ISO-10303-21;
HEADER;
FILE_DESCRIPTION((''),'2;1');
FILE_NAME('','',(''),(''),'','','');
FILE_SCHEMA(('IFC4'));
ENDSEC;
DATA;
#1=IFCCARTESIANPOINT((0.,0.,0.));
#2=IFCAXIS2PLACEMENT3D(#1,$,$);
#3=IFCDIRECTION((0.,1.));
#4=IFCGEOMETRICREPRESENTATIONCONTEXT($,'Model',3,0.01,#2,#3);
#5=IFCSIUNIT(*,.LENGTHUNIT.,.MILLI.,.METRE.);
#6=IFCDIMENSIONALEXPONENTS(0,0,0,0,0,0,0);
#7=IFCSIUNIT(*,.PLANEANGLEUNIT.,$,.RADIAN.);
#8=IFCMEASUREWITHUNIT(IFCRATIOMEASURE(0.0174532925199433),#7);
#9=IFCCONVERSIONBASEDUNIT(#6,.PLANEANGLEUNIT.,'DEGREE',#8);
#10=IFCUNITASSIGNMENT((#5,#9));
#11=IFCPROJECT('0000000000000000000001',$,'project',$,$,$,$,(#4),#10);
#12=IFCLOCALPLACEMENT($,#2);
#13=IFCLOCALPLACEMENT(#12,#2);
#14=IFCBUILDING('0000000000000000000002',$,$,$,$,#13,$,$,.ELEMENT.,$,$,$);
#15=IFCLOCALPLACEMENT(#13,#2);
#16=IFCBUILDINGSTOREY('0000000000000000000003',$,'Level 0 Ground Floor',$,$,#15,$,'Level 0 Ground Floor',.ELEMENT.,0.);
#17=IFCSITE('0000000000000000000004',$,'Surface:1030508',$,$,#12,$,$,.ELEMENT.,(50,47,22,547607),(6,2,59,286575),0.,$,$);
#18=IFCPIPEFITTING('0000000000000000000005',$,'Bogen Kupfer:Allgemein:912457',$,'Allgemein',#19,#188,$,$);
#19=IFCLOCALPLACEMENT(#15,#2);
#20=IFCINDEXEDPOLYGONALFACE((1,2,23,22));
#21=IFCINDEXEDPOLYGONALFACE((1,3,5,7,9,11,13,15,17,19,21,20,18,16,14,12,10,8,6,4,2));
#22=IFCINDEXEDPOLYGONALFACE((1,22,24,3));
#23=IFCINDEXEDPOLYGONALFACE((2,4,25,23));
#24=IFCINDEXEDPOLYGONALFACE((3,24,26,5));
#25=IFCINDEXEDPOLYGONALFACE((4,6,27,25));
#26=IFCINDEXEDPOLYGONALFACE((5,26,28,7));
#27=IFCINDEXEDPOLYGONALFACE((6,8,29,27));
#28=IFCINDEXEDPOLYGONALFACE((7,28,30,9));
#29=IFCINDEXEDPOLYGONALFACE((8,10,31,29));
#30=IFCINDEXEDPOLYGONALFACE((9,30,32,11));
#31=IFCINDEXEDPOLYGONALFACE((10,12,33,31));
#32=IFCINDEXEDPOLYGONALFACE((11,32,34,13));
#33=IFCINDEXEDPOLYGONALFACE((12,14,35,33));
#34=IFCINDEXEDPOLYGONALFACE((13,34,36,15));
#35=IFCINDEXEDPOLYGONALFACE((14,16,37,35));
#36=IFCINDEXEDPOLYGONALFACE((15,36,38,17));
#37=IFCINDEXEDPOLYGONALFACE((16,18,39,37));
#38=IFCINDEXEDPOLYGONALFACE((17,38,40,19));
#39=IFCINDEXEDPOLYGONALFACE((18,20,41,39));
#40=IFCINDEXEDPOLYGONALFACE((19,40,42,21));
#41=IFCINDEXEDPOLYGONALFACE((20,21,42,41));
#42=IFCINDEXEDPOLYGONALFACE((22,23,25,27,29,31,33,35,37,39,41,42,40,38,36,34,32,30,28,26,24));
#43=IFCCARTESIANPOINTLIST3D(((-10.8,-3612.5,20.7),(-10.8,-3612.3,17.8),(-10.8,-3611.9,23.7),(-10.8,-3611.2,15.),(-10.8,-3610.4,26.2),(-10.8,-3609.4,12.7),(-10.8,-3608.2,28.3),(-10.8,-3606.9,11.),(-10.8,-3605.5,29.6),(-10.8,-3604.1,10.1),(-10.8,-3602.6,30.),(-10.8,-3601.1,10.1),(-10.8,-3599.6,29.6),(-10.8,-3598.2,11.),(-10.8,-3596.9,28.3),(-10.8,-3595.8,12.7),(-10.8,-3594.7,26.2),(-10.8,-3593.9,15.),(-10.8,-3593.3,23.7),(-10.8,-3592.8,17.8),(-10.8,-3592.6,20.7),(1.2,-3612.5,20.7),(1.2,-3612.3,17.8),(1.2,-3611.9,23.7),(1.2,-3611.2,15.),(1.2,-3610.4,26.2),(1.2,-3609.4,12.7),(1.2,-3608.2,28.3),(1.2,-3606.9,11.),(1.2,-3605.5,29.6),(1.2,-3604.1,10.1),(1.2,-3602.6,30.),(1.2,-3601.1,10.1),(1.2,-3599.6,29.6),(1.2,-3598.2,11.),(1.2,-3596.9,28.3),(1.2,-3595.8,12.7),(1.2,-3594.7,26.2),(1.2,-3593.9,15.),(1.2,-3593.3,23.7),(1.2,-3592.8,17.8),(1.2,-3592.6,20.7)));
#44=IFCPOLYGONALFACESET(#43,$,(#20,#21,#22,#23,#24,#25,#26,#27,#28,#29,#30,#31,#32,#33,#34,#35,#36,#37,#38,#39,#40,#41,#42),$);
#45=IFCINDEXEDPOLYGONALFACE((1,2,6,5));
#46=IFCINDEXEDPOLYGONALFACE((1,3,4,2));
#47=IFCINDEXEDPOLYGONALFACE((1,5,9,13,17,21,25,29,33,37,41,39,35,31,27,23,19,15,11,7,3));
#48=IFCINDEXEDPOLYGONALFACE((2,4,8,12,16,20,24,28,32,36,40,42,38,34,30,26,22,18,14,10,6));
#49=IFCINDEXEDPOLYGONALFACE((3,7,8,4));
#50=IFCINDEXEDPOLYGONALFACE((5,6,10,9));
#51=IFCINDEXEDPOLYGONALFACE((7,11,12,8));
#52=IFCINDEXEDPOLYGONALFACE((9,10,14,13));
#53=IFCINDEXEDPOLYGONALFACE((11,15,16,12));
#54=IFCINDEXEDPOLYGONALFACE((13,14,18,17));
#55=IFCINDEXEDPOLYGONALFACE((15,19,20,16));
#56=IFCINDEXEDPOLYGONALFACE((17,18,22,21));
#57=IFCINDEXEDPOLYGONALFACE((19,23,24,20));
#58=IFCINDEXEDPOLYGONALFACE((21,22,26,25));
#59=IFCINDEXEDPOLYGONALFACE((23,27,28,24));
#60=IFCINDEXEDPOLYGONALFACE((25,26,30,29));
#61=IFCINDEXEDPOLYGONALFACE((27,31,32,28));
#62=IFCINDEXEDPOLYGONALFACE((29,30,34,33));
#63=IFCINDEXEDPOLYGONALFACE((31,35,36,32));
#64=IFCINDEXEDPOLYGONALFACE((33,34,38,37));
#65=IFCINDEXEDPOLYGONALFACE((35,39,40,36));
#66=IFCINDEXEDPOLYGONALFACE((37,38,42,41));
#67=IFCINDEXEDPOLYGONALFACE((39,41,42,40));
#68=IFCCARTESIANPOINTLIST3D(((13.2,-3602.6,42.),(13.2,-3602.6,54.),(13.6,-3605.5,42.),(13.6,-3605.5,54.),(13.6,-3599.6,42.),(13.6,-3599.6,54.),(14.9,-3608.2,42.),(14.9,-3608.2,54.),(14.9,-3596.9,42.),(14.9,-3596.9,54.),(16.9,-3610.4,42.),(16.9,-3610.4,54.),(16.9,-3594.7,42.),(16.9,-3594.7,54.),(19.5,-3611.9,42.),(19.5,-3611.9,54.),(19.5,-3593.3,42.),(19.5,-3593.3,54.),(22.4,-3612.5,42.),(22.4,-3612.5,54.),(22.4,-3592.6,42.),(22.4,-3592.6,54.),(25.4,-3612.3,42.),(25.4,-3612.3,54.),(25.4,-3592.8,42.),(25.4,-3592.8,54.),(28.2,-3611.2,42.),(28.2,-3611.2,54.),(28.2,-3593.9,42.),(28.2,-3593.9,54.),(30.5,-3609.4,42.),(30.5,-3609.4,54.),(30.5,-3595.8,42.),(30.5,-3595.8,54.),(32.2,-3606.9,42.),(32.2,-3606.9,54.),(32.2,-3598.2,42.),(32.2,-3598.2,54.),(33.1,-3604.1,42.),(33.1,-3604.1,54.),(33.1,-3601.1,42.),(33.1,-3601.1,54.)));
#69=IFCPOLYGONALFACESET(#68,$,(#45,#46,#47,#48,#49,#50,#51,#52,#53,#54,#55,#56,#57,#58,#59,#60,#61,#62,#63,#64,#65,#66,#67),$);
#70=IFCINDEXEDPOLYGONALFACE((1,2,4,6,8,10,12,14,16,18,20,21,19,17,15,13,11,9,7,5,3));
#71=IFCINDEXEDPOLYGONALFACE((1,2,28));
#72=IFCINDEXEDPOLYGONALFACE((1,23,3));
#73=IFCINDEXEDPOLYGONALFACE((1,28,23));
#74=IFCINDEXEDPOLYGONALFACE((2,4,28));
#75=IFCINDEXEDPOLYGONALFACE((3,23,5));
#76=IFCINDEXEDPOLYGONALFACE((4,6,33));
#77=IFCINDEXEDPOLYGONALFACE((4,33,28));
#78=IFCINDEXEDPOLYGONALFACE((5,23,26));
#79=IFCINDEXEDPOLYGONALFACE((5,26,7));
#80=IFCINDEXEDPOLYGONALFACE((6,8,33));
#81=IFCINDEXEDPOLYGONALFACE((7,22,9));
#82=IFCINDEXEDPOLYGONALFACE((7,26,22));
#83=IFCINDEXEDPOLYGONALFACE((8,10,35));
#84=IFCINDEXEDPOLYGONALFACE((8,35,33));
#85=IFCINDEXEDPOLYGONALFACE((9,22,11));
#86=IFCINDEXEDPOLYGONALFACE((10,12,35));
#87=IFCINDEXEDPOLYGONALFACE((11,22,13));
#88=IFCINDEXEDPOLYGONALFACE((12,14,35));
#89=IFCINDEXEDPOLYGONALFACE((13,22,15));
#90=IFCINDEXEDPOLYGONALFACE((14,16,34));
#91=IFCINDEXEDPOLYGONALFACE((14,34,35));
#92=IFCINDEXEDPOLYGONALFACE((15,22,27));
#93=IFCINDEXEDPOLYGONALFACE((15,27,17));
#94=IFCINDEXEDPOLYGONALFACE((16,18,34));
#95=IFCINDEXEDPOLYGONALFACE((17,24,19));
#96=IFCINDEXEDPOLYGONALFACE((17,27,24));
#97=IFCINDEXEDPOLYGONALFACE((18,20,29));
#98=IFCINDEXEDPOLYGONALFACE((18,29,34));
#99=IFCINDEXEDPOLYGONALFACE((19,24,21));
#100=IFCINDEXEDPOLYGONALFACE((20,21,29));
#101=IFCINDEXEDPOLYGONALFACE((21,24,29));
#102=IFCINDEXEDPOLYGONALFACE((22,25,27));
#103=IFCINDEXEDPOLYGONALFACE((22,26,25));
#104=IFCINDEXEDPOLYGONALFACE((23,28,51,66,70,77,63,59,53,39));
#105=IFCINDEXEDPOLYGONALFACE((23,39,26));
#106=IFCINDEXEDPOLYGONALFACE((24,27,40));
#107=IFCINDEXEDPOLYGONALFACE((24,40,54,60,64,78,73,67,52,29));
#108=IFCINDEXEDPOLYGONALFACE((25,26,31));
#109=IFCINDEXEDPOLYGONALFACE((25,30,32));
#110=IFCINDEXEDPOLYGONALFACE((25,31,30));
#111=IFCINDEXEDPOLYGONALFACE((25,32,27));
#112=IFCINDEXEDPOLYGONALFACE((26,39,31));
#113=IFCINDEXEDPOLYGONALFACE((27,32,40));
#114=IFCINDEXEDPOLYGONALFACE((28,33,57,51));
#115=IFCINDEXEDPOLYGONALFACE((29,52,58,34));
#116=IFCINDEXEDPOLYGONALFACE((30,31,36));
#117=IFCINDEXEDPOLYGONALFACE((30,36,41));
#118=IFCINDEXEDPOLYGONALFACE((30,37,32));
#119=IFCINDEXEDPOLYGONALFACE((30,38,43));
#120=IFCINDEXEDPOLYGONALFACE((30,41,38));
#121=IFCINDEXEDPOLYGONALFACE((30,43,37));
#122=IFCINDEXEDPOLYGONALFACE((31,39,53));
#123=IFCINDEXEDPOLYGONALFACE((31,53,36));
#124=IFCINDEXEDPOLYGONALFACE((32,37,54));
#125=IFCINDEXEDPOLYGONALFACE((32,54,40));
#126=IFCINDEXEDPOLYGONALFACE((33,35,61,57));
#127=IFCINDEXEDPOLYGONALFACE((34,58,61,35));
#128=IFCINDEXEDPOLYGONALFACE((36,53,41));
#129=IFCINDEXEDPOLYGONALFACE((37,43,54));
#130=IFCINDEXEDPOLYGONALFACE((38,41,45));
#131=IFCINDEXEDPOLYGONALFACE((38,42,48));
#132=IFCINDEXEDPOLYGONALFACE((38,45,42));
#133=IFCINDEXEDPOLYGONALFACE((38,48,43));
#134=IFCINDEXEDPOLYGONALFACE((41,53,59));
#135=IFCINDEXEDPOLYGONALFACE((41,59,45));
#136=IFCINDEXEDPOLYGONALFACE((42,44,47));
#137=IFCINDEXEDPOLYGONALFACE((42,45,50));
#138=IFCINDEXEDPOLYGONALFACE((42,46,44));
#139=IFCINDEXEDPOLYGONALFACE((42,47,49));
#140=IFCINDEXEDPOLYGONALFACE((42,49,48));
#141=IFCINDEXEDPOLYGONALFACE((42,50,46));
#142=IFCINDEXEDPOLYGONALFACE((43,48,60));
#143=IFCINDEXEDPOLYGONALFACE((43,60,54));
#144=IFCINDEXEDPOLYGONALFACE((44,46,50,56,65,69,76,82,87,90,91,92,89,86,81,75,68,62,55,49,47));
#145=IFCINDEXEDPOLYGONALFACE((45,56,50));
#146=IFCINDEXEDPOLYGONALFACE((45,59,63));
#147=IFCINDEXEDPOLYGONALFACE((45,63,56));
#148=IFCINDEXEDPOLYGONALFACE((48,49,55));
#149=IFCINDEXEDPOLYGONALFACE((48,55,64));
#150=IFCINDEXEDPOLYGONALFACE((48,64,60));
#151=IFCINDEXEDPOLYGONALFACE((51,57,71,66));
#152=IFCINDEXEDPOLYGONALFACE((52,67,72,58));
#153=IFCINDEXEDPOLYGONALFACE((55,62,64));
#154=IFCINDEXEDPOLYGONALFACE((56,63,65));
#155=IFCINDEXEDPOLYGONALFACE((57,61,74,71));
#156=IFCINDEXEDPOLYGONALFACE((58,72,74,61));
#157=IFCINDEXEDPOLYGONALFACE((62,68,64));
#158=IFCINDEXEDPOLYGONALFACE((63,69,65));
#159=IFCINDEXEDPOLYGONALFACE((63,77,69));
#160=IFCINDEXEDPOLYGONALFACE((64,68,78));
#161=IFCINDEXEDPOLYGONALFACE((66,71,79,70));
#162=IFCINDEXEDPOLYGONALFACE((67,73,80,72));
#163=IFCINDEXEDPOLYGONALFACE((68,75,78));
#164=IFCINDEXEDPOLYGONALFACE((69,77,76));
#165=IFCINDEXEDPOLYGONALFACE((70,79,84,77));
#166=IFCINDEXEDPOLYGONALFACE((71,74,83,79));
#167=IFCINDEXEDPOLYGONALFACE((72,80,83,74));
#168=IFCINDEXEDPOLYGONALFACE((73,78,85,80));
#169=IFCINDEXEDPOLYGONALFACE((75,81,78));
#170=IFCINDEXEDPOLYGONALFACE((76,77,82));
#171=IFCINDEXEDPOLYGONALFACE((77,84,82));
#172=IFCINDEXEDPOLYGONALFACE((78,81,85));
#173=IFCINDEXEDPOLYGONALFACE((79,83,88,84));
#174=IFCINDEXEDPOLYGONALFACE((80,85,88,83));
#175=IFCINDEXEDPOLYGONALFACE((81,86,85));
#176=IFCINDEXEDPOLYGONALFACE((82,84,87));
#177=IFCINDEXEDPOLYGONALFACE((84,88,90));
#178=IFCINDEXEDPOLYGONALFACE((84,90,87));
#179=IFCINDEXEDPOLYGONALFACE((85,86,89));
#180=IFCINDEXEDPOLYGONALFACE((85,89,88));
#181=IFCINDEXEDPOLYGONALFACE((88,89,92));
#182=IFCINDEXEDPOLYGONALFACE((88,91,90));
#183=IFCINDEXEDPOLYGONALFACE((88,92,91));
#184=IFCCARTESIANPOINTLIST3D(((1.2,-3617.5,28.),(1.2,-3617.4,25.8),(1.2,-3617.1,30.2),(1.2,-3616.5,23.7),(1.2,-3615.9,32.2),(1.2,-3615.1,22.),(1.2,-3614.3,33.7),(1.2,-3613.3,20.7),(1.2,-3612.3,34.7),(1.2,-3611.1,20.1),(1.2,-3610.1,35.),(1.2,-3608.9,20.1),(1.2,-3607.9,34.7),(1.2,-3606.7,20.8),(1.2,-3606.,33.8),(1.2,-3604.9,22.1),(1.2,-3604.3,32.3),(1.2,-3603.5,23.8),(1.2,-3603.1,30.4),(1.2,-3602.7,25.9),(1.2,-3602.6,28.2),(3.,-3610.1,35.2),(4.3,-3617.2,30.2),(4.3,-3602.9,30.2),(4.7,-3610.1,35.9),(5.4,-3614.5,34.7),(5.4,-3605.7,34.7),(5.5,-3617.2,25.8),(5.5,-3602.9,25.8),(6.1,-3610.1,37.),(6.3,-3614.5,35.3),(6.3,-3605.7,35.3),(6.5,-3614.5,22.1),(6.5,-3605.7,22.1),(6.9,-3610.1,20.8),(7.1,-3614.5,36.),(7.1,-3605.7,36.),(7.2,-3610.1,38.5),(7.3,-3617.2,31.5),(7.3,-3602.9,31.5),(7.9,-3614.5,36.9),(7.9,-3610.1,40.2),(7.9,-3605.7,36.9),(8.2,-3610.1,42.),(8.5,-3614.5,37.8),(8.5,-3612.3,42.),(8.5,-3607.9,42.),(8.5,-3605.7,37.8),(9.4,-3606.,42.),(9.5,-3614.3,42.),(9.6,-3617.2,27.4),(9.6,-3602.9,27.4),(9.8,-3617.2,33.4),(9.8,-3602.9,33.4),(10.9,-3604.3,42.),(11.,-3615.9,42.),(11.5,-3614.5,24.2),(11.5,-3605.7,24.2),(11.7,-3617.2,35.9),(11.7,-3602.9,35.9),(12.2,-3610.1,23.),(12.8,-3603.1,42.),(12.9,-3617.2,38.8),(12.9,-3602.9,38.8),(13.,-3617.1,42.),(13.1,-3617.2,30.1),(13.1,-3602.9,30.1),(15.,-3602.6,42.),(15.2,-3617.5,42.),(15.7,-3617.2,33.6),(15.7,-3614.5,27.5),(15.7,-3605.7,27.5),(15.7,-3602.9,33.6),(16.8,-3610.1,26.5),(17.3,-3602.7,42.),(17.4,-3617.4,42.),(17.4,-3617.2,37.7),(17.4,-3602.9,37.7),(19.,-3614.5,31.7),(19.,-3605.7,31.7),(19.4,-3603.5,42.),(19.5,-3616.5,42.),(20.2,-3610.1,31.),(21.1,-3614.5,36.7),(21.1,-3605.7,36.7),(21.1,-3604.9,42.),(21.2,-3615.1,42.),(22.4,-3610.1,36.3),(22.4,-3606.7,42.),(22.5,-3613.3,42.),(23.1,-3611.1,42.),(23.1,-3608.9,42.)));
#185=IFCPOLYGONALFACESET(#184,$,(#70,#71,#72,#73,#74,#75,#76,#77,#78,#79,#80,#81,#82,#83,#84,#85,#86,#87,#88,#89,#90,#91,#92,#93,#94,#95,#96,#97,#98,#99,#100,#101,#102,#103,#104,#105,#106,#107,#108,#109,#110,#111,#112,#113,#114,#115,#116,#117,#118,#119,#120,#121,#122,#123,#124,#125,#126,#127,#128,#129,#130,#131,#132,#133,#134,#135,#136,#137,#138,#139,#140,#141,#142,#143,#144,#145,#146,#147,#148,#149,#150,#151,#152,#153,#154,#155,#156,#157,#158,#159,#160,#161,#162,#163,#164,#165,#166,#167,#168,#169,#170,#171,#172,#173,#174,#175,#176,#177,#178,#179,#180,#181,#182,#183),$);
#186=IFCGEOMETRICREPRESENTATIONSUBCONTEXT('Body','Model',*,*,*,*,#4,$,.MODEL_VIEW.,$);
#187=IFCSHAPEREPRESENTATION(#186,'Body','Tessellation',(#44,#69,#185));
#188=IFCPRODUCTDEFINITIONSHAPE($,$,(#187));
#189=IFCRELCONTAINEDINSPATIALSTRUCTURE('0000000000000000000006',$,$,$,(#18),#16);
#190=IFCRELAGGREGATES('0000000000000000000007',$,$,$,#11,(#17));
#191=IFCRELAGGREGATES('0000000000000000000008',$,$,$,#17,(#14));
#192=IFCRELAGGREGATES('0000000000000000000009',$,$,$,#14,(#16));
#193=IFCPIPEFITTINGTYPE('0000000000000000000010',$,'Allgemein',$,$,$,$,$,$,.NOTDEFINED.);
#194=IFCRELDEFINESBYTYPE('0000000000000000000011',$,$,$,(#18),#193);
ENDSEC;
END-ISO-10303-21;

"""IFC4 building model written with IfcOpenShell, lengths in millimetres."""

from ifc_helpers import new_model, entity, si_unit, converted_unit, direction, frame, frame_2d, origin, place, context, subcontext, project, spatial, circle, extrude, source, transform, mapped, type_object, type_shapes, element, save


model = new_model("IFC4")

# Units and contexts
model_context = context("Model", 3, precision=0.01, world=origin(), true_north=direction((0.0, 1.0)))
body_context = subcontext(model_context, "Body", "Model", "MODEL_VIEW")
ifc_project = project(units=[si_unit("LENGTHUNIT", "METRE", prefix="MILLI"), converted_unit("PLANEANGLEUNIT", "DEGREE", entity("IfcRatioMeasure", 0.0174532925199433), si_unit("PLANEANGLEUNIT", "RADIAN"), dimensions=[0, 0, 0, 0, 0, 0, 0])], contexts=[model_context])

# Site, building, storey
site_placement = place(None, origin())
site = spatial("IfcSite", under=ifc_project, at=site_placement, Name="Surface:1030508", CompositionType="ELEMENT", RefLatitude=(50, 47, 22, 547607), RefLongitude=(6, 2, 59, 286575), RefElevation=0.0)
building_placement = place(site_placement, origin())
building = spatial("IfcBuilding", under=site, at=building_placement, CompositionType="ELEMENT")
storey_placement = place(building_placement, origin())
storey = spatial("IfcBuildingStorey", under=building, at=storey_placement, Name="Level 0 Ground Floor", LongName="Level 0 Ground Floor", CompositionType="ELEMENT", Elevation=0.0)

# Shared definitions
pipe_fitting_type_1 = type_object("IfcPipeFittingType", Name="Allgemein", PredefinedType="NOTDEFINED")
ifc_direction_1 = entity("IfcDirection", [0.0, 0.0, -1.0])
trimmed_curve_1 = entity("IfcTrimmedCurve", entity("IfcCircle", entity("IfcAxis2Placement2D", entity("IfcCartesianPoint", [-14.5, 0.0]), entity("IfcDirection", [0.0, 1.0])), 14.5), [entity("IfcParameterValue", 270.0)], [entity("IfcParameterValue", 0.0)], True, "PARAMETER")
shared_shape_1 = source(origin(), body_context, "Body", "SolidModel", [
    extrude(circle(Radius=10.0, at=frame_2d((0.0, 0.0), x_axis=(1.0, 0.0))), frame((0.0, 22.0, 0.0), z_axis=(0.0, 1.0, 0.0), x_axis=(-1.0, 0.0, 0.0)), (0.0, 0.0, 1.0), 12.0),
    extrude(circle(Radius=10.0, at=frame_2d((0.0, 0.0), x_axis=(1.0, 0.0))), frame((-34.0, 0.0, 0.0), z_axis=(1.0, 0.0, 0.0), x_axis=(0.0, 1.0, 0.0)), (0.0, 0.0, 1.0), 12.0),
    entity("IfcSurfaceCurveSweptAreaSolid", entity("IfcCircleProfileDef", "AREA", None, entity("IfcAxis2Placement2D", entity("IfcCartesianPoint", [0.0, 7.5]), entity("IfcDirection", [1.0, 0.0])), 7.5), entity("IfcAxis2Placement3D", entity("IfcCartesianPoint", [-7.5, 22.0, 0.0]), ifc_direction_1, entity("IfcDirection", [1.0, 0.0, 0.0])), trimmed_curve_1, 0.0, 90.0, entity("IfcSurfaceOfLinearExtrusion", entity("IfcArbitraryOpenProfileDef", "CURVE", None, trimmed_curve_1), entity("IfcAxis2Placement3D", entity("IfcCartesianPoint", [0.0, 0.0, -304.8])), ifc_direction_1, 1.0)),
])
type_shapes(pipe_fitting_type_1, [shared_shape_1])

# Pipe fitting
pipe_fitting_1_placement = place(storey_placement, frame((23.2, -3602.6, 20.0), z_axis=(0.0, 1.0, 0.0), x_axis=(0.0, 0.0, -1.0)))
element("IfcPipeFitting", 1, at=pipe_fitting_1_placement, inside=storey, type_object=pipe_fitting_type_1, Name="Bogen Kupfer:Allgemein:912457", ObjectType="Allgemein", context=body_context, shape_type="MappedRepresentation", body=[
    mapped(shared_shape_1, transform((0.0, 0.0, 0.0), scale=1.0)),
])

save(model, "model.ifc")
